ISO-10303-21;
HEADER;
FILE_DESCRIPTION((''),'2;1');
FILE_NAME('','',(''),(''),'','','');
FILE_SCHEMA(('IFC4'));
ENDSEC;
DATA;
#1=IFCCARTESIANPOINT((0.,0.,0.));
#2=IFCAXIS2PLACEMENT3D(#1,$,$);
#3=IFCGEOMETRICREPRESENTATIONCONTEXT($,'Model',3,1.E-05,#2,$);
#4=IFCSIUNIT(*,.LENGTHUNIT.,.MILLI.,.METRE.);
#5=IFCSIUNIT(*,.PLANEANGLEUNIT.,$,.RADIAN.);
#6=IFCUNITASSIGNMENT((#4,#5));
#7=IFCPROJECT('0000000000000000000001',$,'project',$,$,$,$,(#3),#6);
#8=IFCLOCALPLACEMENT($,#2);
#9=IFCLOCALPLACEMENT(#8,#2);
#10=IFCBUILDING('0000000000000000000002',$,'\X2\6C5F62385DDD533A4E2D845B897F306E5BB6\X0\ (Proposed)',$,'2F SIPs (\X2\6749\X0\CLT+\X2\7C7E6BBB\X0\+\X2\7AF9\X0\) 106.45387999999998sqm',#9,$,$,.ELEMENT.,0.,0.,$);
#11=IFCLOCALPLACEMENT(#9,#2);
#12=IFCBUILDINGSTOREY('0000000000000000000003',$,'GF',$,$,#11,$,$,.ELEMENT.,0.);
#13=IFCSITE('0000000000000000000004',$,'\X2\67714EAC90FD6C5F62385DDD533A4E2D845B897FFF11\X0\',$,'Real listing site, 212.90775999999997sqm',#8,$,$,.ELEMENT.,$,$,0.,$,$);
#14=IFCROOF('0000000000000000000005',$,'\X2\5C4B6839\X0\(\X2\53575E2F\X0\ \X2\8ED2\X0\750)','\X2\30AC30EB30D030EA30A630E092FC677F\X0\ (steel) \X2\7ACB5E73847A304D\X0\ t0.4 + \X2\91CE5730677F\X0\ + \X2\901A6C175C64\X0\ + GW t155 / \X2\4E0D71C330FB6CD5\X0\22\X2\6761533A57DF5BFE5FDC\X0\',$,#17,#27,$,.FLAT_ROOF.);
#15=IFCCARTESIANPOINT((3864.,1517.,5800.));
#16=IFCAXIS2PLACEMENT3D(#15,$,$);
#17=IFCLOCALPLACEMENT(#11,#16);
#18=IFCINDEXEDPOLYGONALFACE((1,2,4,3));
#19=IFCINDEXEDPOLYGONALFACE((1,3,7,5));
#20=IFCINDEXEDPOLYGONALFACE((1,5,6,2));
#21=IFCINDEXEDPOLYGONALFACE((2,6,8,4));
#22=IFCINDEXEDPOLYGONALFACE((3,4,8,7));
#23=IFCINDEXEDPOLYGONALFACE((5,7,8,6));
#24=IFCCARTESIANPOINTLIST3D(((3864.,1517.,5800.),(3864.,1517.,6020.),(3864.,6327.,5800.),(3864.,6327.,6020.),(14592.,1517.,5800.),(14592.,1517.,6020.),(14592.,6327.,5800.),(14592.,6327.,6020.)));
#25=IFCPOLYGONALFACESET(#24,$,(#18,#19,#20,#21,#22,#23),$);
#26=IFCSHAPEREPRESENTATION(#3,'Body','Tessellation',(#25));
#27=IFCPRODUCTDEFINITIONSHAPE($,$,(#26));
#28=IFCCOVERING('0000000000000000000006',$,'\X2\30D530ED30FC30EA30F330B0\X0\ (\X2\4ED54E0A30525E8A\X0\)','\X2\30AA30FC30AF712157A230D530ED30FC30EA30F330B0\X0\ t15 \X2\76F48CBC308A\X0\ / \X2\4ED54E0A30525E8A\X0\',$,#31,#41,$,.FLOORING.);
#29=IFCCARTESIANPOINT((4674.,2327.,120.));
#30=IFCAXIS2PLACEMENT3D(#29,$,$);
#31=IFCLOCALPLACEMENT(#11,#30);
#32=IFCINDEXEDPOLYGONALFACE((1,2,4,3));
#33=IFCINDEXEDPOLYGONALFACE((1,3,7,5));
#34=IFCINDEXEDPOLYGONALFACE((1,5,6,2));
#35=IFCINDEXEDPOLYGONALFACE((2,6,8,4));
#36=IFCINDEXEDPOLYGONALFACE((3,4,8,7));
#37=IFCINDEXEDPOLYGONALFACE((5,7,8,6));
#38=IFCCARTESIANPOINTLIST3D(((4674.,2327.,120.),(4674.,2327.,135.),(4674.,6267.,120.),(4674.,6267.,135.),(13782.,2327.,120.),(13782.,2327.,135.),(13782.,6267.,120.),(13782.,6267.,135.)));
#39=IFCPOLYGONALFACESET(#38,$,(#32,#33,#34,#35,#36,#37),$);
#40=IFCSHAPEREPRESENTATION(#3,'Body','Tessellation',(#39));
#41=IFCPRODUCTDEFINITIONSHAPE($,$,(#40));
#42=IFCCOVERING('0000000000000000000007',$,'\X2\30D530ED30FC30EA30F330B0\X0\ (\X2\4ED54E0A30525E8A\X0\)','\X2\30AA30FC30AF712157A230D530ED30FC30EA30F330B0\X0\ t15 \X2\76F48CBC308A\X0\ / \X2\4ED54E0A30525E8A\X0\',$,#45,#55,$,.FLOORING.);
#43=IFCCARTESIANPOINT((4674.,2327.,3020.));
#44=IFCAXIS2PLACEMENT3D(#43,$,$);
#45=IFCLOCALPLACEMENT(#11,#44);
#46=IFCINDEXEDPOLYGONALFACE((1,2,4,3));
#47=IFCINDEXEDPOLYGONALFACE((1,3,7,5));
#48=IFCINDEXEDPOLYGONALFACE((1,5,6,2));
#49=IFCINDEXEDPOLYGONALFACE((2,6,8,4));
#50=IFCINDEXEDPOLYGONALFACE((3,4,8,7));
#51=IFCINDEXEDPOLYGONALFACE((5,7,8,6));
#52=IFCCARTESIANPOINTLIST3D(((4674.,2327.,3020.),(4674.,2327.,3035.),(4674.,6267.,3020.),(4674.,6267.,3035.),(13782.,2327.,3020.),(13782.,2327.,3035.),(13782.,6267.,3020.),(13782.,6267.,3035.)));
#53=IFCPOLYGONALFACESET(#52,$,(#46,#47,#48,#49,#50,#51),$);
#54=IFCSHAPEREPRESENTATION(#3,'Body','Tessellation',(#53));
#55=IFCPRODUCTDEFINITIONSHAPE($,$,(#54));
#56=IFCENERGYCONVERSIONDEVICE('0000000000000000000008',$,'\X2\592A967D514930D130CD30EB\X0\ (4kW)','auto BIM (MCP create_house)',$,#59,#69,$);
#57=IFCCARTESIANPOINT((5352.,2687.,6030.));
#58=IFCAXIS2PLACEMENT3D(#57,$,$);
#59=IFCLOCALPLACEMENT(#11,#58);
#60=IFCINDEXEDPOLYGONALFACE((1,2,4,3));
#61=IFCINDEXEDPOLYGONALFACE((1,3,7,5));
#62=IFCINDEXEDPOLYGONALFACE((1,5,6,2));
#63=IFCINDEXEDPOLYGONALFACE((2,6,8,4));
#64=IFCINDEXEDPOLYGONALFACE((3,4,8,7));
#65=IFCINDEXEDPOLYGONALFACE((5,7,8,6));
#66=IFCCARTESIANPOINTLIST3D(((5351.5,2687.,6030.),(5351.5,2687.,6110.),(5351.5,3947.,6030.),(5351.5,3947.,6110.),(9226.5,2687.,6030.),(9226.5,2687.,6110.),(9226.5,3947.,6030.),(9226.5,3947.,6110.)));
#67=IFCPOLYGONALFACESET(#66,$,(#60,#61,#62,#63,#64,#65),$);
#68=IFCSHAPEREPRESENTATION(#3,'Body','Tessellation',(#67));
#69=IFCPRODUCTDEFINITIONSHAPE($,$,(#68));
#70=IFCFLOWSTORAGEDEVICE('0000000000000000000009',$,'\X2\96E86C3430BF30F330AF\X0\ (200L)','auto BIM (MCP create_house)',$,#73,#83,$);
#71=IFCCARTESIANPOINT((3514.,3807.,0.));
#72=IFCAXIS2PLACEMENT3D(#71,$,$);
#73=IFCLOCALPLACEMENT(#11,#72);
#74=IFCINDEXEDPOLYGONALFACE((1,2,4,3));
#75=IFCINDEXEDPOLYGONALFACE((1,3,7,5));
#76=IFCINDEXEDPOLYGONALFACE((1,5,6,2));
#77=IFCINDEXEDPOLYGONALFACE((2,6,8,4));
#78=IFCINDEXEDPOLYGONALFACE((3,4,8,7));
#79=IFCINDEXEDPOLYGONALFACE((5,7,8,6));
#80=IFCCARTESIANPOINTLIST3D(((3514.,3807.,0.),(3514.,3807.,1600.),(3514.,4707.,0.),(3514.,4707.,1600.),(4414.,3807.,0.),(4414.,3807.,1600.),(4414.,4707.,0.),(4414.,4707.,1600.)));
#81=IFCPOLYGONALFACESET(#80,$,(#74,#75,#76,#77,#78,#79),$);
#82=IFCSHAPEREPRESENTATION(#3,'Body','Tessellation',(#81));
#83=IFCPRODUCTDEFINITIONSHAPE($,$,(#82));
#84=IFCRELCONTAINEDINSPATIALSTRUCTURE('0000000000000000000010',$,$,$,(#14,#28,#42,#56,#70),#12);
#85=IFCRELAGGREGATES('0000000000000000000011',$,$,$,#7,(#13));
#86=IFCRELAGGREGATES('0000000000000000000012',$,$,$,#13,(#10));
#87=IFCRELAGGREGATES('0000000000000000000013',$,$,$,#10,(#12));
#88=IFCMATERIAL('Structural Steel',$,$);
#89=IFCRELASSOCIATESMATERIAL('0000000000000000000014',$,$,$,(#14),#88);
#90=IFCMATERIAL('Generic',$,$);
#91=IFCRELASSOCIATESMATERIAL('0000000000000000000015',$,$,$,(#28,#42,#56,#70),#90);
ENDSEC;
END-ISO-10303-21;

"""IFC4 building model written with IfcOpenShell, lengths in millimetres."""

from ifc_helpers import new_model, si_unit, frame, frame_2d, origin, place, context, project, spatial, rectangle, extrude, material, element, save


model = new_model("IFC4")

# Units and contexts
model_context = context("Model", 3, precision=1e-05, world=origin())
ifc_project = project(units=[si_unit("LENGTHUNIT", "METRE", prefix="MILLI"), si_unit("PLANEANGLEUNIT", "RADIAN")], contexts=[model_context])

# Site, building, storey
site_placement = place(None, origin())
site = spatial("IfcSite", under=ifc_project, at=site_placement, Name="東京都江戸川区中葛西１", ObjectType="Real listing site, 212.90775999999997sqm", CompositionType="ELEMENT", RefElevation=0.0)
building_placement = place(site_placement, origin())
building = spatial("IfcBuilding", under=site, at=building_placement, Name="江戸川区中葛西の家 (Proposed)", ObjectType="2F SIPs (杉CLT+籾殻+竹) 106.45387999999998sqm", CompositionType="ELEMENT", ElevationOfRefHeight=0.0, ElevationOfTerrain=0.0)
storey_placement = place(building_placement, origin())
storey = spatial("IfcBuildingStorey", under=building, at=storey_placement, Name="GF", CompositionType="ELEMENT", Elevation=0.0)

# Roof
ifc_material_1 = material(Name="Structural Steel")
for number, where, name in (
    (1, (3864.0, 1517.0, 5800.0), "屋根(南帯 軒750)"),
):
    element("IfcRoof", number, at=place(storey_placement, frame(where)), inside=storey, material=ifc_material_1, Name=name, Description="ガルバリウム鋼板 (steel) 立平葺き t0.4 + 野地板 + 通気層 + GW t155 / 不燃・法22条区域対応", PredefinedType="FLAT_ROOF", context=model_context, shape_type="SweptSolid", body=[
        extrude(rectangle(XDim=10728.0, YDim=4810.0, at=frame_2d((5364.0, 2405.0))), frame((3864.0, 1517.0, 5800.0)), (0.0, 0.0, 1.0), 220.0),
    ])

# Coverings
ifc_material_2 = material(Name="Generic")
covering_1_placement = place(storey_placement, frame((4674.0, 2327.0, 120.0)))
element("IfcCovering", 2, at=covering_1_placement, inside=storey, material=ifc_material_2, Name="フローリング (仕上げ床)", Description="オーク無垢フローリング t15 直貼り / 仕上げ床", PredefinedType="FLOORING", context=model_context, shape_type="SweptSolid", body=[
    extrude(rectangle(XDim=9108.0, YDim=3940.0, at=frame_2d((4554.0, 1970.0))), frame((4674.0, 2327.0, 120.0)), (0.0, 0.0, 1.0), 15.0),
])
covering_2_placement = place(storey_placement, frame((4674.0, 2327.0, 3020.0)))
element("IfcCovering", 3, at=covering_2_placement, inside=storey, material=ifc_material_2, Name="フローリング (仕上げ床)", Description="オーク無垢フローリング t15 直貼り / 仕上げ床", PredefinedType="FLOORING", context=model_context, shape_type="SweptSolid", body=[
    extrude(rectangle(XDim=9108.0, YDim=3940.0, at=frame_2d((4554.0, 1970.0))), frame((4674.0, 2327.0, 3020.0)), (0.0, 0.0, 1.0), 15.0),
])

# Energy conversion device
energy_conversion_device_placement = place(storey_placement, frame((5352.0, 2687.0, 6030.0)))
element("IfcEnergyConversionDevice", 4, at=energy_conversion_device_placement, inside=storey, material=ifc_material_2, Name="太陽光パネル (4kW)", Description="auto BIM (MCP create_house)", context=model_context, shape_type="SweptSolid", body=[
    extrude(rectangle(XDim=3875.0, YDim=1260.0, at=frame_2d((1937.0, 630.0))), frame((5352.0, 2687.0, 6030.0)), (0.0, 0.0, 1.0), 80.0),
])

# Flow storage device
flow_storage_device_placement = place(storey_placement, frame((3514.0, 3807.0, 0.0)))
element("IfcFlowStorageDevice", 5, at=flow_storage_device_placement, inside=storey, material=ifc_material_2, Name="雨水タンク (200L)", Description="auto BIM (MCP create_house)", context=model_context, shape_type="SweptSolid", body=[
    extrude(rectangle(XDim=900.0, YDim=900.0, at=frame_2d((450.0, 450.0))), frame((3514.0, 3807.0, 0.0)), (0.0, 0.0, 1.0), 1600.0),
])

save(model, "model.ifc")
